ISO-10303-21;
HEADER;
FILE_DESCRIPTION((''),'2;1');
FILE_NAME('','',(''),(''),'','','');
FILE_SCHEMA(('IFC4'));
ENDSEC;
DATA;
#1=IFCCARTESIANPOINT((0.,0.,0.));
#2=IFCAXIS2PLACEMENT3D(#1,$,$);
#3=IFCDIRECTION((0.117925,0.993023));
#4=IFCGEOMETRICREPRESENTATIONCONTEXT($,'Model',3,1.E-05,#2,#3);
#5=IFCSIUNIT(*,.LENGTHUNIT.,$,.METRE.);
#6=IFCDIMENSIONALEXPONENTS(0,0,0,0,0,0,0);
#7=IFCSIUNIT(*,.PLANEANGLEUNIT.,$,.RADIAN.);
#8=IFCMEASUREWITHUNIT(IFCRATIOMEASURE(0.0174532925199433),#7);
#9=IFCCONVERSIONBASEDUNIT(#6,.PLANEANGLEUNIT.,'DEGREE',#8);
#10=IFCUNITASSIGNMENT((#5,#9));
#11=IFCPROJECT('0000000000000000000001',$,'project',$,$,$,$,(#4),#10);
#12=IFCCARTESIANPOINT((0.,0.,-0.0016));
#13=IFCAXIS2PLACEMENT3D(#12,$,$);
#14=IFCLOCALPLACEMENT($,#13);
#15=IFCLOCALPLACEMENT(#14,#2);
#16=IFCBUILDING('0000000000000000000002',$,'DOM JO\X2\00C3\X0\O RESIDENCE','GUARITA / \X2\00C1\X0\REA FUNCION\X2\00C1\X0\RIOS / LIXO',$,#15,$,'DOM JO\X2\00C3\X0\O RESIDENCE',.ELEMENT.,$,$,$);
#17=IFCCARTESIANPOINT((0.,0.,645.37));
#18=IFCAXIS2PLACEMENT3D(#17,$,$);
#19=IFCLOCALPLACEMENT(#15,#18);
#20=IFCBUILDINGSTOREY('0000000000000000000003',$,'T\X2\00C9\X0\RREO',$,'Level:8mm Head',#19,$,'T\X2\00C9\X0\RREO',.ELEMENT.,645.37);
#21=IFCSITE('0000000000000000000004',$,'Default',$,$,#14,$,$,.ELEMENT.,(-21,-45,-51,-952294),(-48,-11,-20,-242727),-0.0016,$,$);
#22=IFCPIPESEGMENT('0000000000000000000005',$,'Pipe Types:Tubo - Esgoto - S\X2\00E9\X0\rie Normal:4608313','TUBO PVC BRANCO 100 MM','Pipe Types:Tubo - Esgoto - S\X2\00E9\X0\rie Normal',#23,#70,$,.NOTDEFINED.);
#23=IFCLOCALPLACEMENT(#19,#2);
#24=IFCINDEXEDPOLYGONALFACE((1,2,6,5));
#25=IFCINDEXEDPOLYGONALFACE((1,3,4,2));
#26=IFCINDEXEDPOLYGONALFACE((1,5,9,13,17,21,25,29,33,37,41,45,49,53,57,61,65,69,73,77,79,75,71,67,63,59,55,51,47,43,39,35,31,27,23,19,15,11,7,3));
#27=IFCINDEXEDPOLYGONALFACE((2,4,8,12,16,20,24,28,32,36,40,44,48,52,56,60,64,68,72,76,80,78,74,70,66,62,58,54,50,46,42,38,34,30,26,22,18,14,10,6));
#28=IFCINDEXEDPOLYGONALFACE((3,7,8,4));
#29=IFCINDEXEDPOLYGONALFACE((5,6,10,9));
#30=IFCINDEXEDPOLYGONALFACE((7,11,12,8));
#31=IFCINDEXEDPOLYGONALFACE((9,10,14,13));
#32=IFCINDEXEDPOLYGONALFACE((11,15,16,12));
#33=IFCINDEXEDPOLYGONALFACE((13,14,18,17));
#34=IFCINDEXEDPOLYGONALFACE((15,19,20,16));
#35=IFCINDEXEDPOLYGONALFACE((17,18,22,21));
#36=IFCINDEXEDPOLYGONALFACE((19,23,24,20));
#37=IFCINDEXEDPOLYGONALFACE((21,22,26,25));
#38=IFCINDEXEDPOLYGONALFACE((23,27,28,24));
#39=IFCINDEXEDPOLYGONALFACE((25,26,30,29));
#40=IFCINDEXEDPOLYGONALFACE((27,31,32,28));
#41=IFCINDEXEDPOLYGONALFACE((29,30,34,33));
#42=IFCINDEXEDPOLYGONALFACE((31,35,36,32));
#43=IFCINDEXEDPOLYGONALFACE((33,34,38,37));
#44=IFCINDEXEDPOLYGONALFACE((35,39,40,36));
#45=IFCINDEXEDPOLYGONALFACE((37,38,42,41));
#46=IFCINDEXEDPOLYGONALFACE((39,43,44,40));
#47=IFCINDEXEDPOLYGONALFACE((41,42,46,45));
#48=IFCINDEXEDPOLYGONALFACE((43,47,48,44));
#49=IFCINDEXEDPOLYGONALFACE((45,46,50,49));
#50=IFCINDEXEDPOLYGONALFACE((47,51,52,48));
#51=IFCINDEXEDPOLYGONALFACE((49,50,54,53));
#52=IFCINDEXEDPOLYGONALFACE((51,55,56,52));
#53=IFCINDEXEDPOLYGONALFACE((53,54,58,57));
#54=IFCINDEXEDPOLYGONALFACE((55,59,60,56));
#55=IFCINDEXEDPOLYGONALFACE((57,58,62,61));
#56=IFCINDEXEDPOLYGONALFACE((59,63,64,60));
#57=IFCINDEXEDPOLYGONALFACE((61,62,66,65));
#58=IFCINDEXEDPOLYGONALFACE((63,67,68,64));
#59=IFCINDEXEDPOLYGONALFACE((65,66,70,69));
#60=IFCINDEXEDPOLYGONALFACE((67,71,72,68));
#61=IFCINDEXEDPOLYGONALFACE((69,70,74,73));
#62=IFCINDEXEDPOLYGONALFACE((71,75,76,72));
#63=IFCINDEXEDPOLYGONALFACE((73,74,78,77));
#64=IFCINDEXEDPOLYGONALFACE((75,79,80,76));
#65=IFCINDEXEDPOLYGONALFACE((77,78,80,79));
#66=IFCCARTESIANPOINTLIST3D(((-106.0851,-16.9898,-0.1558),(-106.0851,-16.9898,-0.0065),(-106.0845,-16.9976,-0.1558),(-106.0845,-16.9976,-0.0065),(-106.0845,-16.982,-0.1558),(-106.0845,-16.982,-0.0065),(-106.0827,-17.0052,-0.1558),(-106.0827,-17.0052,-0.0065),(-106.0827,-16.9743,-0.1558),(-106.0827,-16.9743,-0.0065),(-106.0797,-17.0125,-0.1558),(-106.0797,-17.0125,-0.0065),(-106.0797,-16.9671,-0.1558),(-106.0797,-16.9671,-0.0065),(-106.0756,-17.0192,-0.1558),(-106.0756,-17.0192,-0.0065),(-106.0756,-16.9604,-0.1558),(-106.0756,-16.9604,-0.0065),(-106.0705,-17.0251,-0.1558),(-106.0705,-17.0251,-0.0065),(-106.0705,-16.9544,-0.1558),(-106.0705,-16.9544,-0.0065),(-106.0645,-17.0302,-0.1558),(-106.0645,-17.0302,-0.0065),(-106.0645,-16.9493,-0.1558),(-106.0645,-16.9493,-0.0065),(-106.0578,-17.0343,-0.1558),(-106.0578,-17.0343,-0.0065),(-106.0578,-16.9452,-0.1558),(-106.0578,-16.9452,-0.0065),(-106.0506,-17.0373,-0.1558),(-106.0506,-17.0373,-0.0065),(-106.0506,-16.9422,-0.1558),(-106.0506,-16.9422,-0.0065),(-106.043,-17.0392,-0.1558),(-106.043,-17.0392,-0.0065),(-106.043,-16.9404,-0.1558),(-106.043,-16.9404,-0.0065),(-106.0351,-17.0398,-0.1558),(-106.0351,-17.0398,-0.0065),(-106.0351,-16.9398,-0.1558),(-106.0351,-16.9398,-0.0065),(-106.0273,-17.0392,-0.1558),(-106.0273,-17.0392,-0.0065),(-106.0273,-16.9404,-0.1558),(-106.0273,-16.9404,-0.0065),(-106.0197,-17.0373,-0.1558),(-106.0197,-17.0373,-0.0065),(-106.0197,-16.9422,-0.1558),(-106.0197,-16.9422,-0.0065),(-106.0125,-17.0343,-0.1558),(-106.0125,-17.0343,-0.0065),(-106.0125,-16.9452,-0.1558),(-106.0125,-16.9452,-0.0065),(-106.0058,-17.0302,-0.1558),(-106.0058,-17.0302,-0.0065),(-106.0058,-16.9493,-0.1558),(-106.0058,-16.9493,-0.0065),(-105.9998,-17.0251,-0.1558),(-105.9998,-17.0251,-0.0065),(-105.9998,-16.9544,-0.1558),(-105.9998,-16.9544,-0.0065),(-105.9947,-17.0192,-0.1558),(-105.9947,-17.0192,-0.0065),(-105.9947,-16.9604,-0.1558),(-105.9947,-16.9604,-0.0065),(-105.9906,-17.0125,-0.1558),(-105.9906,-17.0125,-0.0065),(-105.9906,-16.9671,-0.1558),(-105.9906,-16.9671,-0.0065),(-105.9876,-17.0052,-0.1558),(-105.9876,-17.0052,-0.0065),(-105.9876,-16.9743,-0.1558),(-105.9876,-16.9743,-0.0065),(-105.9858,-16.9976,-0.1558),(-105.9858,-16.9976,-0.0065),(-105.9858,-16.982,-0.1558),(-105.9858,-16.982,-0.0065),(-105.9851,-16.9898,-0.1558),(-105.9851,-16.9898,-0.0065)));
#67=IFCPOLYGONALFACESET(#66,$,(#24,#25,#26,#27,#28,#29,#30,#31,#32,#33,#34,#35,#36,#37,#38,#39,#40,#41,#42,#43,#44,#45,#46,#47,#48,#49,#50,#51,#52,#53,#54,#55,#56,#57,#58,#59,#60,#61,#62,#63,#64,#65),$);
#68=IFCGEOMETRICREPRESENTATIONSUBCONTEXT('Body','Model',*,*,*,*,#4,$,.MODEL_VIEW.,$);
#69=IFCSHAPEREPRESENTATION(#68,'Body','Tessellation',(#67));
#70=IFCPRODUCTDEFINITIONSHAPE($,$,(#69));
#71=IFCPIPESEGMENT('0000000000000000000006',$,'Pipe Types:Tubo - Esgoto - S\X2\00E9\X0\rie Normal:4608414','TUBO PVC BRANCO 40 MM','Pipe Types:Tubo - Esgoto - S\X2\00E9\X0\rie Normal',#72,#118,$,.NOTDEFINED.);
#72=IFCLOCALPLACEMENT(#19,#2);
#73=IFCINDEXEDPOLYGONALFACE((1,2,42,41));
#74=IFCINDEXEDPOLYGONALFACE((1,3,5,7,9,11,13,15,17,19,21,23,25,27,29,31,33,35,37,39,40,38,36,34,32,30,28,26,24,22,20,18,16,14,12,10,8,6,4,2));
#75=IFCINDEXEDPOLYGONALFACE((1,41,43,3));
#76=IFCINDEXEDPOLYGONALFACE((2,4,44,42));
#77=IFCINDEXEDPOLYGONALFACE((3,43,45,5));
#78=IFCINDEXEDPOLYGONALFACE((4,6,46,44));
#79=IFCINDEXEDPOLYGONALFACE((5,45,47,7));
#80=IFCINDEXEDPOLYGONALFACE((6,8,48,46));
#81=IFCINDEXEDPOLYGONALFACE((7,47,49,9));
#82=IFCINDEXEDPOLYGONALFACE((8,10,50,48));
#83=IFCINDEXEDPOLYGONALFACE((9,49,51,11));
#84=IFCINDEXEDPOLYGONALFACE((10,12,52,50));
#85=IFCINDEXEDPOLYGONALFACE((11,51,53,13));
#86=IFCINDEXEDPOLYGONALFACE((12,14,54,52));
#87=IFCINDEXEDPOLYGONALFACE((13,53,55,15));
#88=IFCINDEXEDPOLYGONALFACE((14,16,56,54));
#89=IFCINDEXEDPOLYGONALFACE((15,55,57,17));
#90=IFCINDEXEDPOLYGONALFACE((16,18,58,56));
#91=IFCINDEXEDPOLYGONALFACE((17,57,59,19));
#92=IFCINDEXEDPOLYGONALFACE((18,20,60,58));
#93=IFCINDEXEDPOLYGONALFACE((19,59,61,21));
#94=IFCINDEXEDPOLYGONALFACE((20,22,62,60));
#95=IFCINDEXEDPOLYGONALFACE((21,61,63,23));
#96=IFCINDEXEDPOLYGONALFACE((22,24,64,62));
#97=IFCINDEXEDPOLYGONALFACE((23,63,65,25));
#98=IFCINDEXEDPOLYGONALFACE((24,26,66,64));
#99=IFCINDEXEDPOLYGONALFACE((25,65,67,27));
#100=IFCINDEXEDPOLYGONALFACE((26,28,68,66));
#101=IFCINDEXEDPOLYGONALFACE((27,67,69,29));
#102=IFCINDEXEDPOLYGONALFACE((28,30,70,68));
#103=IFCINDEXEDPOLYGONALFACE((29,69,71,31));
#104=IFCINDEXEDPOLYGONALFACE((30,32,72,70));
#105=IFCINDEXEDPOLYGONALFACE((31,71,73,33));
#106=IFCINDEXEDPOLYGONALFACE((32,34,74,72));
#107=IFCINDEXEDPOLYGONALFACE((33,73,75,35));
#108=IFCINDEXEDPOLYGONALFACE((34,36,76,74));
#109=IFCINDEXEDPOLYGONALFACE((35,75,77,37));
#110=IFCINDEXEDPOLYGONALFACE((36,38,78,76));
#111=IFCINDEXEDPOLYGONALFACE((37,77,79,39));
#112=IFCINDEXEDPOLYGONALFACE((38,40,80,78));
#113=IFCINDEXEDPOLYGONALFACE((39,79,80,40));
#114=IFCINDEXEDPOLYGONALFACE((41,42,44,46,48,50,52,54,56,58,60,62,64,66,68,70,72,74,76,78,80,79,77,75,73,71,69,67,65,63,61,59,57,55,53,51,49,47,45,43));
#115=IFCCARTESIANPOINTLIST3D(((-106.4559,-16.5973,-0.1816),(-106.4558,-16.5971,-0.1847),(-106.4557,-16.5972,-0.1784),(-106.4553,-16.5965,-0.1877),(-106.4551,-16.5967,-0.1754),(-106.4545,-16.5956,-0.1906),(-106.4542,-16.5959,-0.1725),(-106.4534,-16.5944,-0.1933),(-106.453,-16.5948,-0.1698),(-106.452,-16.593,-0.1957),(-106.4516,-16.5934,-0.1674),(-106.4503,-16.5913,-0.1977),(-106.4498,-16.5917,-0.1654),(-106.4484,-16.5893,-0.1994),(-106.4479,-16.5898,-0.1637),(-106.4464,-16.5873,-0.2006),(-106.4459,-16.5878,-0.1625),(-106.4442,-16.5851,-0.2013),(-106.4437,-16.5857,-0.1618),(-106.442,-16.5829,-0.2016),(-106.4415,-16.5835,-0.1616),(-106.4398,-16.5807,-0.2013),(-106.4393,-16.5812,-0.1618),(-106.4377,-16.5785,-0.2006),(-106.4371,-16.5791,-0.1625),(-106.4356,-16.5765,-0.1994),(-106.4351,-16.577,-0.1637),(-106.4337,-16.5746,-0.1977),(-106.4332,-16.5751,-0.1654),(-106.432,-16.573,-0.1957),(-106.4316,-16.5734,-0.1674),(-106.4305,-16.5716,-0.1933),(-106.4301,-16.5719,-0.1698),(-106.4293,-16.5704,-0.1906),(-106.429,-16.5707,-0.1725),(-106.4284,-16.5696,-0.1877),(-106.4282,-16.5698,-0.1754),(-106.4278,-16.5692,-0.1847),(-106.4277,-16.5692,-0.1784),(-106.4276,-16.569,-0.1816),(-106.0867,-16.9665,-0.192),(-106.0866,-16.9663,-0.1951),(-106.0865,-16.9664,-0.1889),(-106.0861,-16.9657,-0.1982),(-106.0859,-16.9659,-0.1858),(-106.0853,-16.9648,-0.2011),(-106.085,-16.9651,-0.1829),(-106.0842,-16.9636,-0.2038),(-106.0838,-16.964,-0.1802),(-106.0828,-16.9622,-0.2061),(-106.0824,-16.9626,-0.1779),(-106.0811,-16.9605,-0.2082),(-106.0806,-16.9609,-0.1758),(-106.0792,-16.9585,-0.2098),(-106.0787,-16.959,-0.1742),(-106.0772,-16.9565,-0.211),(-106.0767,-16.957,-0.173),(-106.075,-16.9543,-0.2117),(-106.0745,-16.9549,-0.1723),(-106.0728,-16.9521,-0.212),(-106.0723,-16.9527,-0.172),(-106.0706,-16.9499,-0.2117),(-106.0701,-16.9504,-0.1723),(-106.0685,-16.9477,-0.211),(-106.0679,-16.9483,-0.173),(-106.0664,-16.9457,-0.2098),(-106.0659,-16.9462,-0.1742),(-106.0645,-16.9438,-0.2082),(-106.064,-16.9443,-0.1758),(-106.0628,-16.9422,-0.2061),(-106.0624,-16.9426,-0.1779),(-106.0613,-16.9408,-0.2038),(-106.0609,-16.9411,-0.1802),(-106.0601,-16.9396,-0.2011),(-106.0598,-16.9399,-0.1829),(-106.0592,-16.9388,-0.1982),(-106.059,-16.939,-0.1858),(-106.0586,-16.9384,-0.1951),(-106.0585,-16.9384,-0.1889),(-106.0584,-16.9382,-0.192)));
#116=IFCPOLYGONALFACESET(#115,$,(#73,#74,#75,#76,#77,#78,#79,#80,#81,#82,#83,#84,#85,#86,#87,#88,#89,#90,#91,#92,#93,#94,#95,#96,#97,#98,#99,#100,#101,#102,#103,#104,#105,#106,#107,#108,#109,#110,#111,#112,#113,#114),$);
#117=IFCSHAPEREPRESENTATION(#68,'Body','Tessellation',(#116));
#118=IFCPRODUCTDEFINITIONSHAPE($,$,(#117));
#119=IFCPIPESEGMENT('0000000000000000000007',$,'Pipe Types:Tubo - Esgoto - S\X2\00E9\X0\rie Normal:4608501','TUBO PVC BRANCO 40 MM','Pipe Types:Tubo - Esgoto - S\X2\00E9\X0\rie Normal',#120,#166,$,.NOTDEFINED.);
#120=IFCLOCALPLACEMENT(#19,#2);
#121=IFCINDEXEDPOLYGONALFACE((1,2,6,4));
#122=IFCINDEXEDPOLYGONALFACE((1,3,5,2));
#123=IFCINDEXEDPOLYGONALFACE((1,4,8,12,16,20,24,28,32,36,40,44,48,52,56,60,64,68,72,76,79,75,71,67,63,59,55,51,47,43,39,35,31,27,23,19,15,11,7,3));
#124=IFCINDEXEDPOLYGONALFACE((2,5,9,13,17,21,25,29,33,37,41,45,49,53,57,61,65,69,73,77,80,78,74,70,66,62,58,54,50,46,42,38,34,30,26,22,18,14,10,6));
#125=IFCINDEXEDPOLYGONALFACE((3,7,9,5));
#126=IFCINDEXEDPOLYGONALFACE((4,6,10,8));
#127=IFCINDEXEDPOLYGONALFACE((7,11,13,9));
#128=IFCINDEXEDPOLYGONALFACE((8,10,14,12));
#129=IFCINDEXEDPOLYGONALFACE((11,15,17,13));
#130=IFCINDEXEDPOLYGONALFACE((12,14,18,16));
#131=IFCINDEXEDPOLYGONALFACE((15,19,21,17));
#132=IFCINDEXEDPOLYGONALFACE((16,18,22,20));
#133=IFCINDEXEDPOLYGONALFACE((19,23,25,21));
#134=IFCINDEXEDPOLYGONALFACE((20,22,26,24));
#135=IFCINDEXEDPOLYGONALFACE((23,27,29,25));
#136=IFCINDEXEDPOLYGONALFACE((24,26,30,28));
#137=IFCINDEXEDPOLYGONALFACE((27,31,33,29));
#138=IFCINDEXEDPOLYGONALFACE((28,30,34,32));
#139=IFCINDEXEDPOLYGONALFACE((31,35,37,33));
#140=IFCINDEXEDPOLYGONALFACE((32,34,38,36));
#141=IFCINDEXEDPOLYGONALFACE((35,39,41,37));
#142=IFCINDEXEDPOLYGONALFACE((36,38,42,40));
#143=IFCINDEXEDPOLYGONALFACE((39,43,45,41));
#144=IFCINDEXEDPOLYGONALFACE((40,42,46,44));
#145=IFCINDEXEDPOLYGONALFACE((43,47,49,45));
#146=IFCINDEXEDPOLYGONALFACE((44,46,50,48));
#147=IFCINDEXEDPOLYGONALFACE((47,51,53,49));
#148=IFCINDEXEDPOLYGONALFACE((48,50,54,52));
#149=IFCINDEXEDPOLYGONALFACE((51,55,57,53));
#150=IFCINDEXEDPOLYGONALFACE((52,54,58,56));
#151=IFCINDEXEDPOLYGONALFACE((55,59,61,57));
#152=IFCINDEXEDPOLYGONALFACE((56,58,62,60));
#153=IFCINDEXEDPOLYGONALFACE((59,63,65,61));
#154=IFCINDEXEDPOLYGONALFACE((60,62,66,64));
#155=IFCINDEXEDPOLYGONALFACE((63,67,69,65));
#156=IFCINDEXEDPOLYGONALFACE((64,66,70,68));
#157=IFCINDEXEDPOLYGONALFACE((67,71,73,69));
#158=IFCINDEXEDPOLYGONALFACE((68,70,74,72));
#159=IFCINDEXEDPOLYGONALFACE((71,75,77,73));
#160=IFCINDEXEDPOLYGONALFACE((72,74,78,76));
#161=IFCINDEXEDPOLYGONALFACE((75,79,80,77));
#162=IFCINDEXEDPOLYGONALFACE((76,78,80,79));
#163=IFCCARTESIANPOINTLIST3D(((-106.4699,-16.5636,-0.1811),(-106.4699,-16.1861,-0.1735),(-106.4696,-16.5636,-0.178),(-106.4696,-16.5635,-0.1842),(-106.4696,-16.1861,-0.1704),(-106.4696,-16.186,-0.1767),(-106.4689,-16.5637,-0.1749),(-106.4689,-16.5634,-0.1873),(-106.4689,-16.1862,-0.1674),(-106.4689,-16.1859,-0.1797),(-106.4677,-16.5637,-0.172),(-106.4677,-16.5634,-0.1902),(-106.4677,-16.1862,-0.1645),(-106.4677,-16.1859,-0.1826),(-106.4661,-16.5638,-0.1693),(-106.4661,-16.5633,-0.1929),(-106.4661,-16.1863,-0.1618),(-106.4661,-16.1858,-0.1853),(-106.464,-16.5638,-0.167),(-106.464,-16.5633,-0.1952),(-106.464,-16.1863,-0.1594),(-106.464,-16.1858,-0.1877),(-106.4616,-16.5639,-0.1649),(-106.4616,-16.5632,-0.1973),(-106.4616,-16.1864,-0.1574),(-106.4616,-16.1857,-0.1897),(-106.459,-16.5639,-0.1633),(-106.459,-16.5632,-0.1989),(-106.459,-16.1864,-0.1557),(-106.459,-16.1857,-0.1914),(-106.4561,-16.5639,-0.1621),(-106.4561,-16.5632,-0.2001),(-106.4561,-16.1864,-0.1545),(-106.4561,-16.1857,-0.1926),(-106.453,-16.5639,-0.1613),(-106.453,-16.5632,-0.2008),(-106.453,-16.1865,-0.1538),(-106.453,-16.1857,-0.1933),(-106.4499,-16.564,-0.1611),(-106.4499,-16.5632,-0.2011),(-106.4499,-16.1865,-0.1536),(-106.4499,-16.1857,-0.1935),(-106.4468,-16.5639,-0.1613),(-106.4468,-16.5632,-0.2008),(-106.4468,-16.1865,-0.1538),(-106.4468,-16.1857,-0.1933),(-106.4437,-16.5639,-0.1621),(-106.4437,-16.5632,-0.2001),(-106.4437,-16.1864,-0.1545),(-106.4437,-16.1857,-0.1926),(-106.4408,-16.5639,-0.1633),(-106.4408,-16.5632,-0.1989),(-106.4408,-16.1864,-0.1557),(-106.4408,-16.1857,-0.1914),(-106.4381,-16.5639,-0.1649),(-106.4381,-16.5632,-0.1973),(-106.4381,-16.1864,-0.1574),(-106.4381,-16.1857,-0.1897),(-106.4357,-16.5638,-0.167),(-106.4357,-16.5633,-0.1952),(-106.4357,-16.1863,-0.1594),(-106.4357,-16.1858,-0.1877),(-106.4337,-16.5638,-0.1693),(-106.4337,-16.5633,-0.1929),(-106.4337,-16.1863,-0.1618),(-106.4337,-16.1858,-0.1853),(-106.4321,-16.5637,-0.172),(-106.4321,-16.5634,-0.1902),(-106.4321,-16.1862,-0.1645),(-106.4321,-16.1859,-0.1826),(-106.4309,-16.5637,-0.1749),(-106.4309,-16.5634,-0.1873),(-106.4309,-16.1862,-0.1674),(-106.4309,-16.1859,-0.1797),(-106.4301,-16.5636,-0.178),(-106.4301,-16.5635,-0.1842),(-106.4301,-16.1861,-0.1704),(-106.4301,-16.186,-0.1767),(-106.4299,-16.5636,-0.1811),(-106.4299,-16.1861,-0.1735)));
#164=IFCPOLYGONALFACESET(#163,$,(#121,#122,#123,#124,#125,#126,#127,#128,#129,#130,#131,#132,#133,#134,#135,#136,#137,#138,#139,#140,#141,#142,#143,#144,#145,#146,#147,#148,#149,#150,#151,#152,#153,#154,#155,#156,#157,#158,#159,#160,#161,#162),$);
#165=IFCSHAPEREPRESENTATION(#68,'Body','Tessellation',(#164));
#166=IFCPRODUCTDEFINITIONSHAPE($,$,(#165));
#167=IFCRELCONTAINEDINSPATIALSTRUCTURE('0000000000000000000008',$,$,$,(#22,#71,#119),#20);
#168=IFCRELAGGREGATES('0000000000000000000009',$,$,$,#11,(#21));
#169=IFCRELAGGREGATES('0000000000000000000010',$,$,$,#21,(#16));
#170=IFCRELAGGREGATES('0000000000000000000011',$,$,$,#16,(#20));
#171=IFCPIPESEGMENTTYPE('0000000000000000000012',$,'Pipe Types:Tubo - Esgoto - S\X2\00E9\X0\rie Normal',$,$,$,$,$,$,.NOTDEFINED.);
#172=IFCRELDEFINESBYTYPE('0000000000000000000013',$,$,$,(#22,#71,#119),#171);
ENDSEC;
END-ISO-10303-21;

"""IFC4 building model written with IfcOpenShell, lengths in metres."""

from ifc_helpers import new_model, entity, si_unit, converted_unit, direction, frame, origin, place, context, subcontext, project, spatial, indexed_curve, outline, extrude, type_object, element, save


model = new_model("IFC4")

# Units and contexts
model_context = context("Model", 3, precision=1e-05, world=origin(), true_north=direction((0.117925, 0.993023)))
body_context = subcontext(model_context, "Body", "Model", "MODEL_VIEW")
ifc_project = project(units=[si_unit("LENGTHUNIT", "METRE"), converted_unit("PLANEANGLEUNIT", "DEGREE", entity("IfcRatioMeasure", 0.0174532925199433), si_unit("PLANEANGLEUNIT", "RADIAN"), dimensions=[0, 0, 0, 0, 0, 0, 0])], contexts=[model_context])

# Site, building, storey
site_placement = place(None, frame((0.0, 0.0, -0.0016)))
site = spatial("IfcSite", under=ifc_project, at=site_placement, Name="Default", CompositionType="ELEMENT", RefLatitude=(-21, -45, -51, -952294), RefLongitude=(-48, -11, -20, -242727), RefElevation=-0.0016)
building_placement = place(site_placement, origin())
building = spatial("IfcBuilding", under=site, at=building_placement, Name="DOM JOÃO RESIDENCE", Description="GUARITA / ÁREA FUNCIONÁRIOS / LIXO", LongName="DOM JOÃO RESIDENCE", CompositionType="ELEMENT")
storey_placement = place(building_placement, frame((0.0, 0.0, 645.37)))
storey = spatial("IfcBuildingStorey", under=building, at=storey_placement, Name="TÉRREO", ObjectType="Level:8mm Head", LongName="TÉRREO", CompositionType="ELEMENT", Elevation=645.37)

# Pipe segments
pipe_segment_type_1 = type_object("IfcPipeSegmentType", Name="Pipe Types:Tubo - Esgoto - Série Normal", PredefinedType="NOTDEFINED")
pipe_segment_1_placement = place(storey_placement, frame((-106.0867, -17.0414, -0.1558)))
element("IfcPipeSegment", 1, at=pipe_segment_1_placement, inside=storey, type_object=pipe_segment_type_1, Name="Pipe Types:Tubo - Esgoto - Série Normal:4608313", Description="TUBO PVC BRANCO 100 MM", ObjectType="Pipe Types:Tubo - Esgoto - Série Normal", PredefinedType="NOTDEFINED", context=body_context, shape_type="SweptSolid", body=[
    extrude(outline(indexed_curve([(0.05, 0.0), (0.0494, 0.0078), (0.0476, 0.0155), (0.0446, 0.0227), (0.0405, 0.0294), (0.0354, 0.0354), (0.0294, 0.0405), (0.0227, 0.0446), (0.0155, 0.0476), (0.0078, 0.0494), (0.0, 0.05), (-0.0078, 0.0494), (-0.0155, 0.0476), (-0.0227, 0.0446), (-0.0294, 0.0405), (-0.0354, 0.0354), (-0.0405, 0.0294), (-0.0446, 0.0227), (-0.0476, 0.0155), (-0.0494, 0.0078), (-0.05, 0.0), (-0.0494, -0.0078), (-0.0476, -0.0155), (-0.0446, -0.0227), (-0.0405, -0.0294), (-0.0354, -0.0354), (-0.0294, -0.0405), (-0.0227, -0.0446), (-0.0155, -0.0476), (-0.0078, -0.0494), (0.0, -0.05), (0.0078, -0.0494), (0.0155, -0.0476), (0.0227, -0.0446), (0.0294, -0.0405), (0.0354, -0.0354), (0.0405, -0.0294), (0.0446, -0.0227), (0.0476, -0.0155), (0.0494, -0.0078), (0.05, 0.0)], self_intersect=False)), frame((0.0516, 0.0516, 0.0), z_axis=(0.0, 0.0, 1.0), x_axis=(-1.0, 0.0, 0.0)), (0.0, 0.0, 1.0), 0.1493),
])
pipe_segment_2_placement = place(storey_placement, frame((-106.4575, -16.9681, -0.2136)))
element("IfcPipeSegment", 2, at=pipe_segment_2_placement, inside=storey, type_object=pipe_segment_type_1, Name="Pipe Types:Tubo - Esgoto - Série Normal:4608414", Description="TUBO PVC BRANCO 40 MM", ObjectType="Pipe Types:Tubo - Esgoto - Série Normal", PredefinedType="NOTDEFINED", context=body_context, shape_type="SweptSolid", body=[
    extrude(outline(indexed_curve([(0.02, 0.0), (0.0198, 0.0031), (0.019, 0.0062), (0.0178, 0.0091), (0.0162, 0.0118), (0.0141, 0.0141), (0.0118, 0.0162), (0.0091, 0.0178), (0.0062, 0.019), (0.0031, 0.0198), (0.0, 0.02), (-0.0031, 0.0198), (-0.0062, 0.019), (-0.0091, 0.0178), (-0.0118, 0.0162), (-0.0141, 0.0141), (-0.0162, 0.0118), (-0.0178, 0.0091), (-0.019, 0.0062), (-0.0198, 0.0031), (-0.02, 0.0), (-0.0198, -0.0031), (-0.019, -0.0062), (-0.0178, -0.0091), (-0.0162, -0.0118), (-0.0141, -0.0141), (-0.0118, -0.0162), (-0.0091, -0.0178), (-0.0062, -0.019), (-0.0031, -0.0198), (0.0, -0.02), (0.0031, -0.0198), (0.0062, -0.019), (0.0091, -0.0178), (0.0118, -0.0162), (0.0141, -0.0141), (0.0162, -0.0118), (0.0178, -0.0091), (0.019, -0.0062), (0.0198, -0.0031), (0.02, 0.0)], self_intersect=False)), frame((0.3849, 0.0157, 0.0216), z_axis=(-0.706965, 0.706965, 0.019996), x_axis=(0.707107, 0.707107, 0.0)), (0.0, 0.0, 1.0), 0.5222),
])
pipe_segment_3_placement = place(storey_placement, frame((-106.4715, -16.5655, -0.2027)))
element("IfcPipeSegment", 3, at=pipe_segment_3_placement, inside=storey, type_object=pipe_segment_type_1, Name="Pipe Types:Tubo - Esgoto - Série Normal:4608501", Description="TUBO PVC BRANCO 40 MM", ObjectType="Pipe Types:Tubo - Esgoto - Série Normal", PredefinedType="NOTDEFINED", context=body_context, shape_type="SweptSolid", body=[
    extrude(outline(indexed_curve([(0.02, 0.0), (0.0198, 0.0031), (0.019, 0.0062), (0.0178, 0.0091), (0.0162, 0.0118), (0.0141, 0.0141), (0.0118, 0.0162), (0.0091, 0.0178), (0.0062, 0.019), (0.0031, 0.0198), (0.0, 0.02), (-0.0031, 0.0198), (-0.0062, 0.019), (-0.0091, 0.0178), (-0.0118, 0.0162), (-0.0141, 0.0141), (-0.0162, 0.0118), (-0.0178, 0.0091), (-0.019, 0.0062), (-0.0198, 0.0031), (-0.02, 0.0), (-0.0198, -0.0031), (-0.019, -0.0062), (-0.0178, -0.0091), (-0.0162, -0.0118), (-0.0141, -0.0141), (-0.0118, -0.0162), (-0.0091, -0.0178), (-0.0062, -0.019), (-0.0031, -0.0198), (0.0, -0.02), (0.0031, -0.0198), (0.0062, -0.019), (0.0091, -0.0178), (0.0118, -0.0162), (0.0141, -0.0141), (0.0162, -0.0118), (0.0178, -0.0091), (0.019, -0.0062), (0.0198, -0.0031), (0.02, 0.0)], self_intersect=False)), frame((0.0216, 0.002, 0.0216), z_axis=(0.0, 0.9998, 0.019996), x_axis=(-1.0, 0.0, 0.0)), (0.0, 0.0, 1.0), 0.3776),
])

save(model, "model.ifc")
